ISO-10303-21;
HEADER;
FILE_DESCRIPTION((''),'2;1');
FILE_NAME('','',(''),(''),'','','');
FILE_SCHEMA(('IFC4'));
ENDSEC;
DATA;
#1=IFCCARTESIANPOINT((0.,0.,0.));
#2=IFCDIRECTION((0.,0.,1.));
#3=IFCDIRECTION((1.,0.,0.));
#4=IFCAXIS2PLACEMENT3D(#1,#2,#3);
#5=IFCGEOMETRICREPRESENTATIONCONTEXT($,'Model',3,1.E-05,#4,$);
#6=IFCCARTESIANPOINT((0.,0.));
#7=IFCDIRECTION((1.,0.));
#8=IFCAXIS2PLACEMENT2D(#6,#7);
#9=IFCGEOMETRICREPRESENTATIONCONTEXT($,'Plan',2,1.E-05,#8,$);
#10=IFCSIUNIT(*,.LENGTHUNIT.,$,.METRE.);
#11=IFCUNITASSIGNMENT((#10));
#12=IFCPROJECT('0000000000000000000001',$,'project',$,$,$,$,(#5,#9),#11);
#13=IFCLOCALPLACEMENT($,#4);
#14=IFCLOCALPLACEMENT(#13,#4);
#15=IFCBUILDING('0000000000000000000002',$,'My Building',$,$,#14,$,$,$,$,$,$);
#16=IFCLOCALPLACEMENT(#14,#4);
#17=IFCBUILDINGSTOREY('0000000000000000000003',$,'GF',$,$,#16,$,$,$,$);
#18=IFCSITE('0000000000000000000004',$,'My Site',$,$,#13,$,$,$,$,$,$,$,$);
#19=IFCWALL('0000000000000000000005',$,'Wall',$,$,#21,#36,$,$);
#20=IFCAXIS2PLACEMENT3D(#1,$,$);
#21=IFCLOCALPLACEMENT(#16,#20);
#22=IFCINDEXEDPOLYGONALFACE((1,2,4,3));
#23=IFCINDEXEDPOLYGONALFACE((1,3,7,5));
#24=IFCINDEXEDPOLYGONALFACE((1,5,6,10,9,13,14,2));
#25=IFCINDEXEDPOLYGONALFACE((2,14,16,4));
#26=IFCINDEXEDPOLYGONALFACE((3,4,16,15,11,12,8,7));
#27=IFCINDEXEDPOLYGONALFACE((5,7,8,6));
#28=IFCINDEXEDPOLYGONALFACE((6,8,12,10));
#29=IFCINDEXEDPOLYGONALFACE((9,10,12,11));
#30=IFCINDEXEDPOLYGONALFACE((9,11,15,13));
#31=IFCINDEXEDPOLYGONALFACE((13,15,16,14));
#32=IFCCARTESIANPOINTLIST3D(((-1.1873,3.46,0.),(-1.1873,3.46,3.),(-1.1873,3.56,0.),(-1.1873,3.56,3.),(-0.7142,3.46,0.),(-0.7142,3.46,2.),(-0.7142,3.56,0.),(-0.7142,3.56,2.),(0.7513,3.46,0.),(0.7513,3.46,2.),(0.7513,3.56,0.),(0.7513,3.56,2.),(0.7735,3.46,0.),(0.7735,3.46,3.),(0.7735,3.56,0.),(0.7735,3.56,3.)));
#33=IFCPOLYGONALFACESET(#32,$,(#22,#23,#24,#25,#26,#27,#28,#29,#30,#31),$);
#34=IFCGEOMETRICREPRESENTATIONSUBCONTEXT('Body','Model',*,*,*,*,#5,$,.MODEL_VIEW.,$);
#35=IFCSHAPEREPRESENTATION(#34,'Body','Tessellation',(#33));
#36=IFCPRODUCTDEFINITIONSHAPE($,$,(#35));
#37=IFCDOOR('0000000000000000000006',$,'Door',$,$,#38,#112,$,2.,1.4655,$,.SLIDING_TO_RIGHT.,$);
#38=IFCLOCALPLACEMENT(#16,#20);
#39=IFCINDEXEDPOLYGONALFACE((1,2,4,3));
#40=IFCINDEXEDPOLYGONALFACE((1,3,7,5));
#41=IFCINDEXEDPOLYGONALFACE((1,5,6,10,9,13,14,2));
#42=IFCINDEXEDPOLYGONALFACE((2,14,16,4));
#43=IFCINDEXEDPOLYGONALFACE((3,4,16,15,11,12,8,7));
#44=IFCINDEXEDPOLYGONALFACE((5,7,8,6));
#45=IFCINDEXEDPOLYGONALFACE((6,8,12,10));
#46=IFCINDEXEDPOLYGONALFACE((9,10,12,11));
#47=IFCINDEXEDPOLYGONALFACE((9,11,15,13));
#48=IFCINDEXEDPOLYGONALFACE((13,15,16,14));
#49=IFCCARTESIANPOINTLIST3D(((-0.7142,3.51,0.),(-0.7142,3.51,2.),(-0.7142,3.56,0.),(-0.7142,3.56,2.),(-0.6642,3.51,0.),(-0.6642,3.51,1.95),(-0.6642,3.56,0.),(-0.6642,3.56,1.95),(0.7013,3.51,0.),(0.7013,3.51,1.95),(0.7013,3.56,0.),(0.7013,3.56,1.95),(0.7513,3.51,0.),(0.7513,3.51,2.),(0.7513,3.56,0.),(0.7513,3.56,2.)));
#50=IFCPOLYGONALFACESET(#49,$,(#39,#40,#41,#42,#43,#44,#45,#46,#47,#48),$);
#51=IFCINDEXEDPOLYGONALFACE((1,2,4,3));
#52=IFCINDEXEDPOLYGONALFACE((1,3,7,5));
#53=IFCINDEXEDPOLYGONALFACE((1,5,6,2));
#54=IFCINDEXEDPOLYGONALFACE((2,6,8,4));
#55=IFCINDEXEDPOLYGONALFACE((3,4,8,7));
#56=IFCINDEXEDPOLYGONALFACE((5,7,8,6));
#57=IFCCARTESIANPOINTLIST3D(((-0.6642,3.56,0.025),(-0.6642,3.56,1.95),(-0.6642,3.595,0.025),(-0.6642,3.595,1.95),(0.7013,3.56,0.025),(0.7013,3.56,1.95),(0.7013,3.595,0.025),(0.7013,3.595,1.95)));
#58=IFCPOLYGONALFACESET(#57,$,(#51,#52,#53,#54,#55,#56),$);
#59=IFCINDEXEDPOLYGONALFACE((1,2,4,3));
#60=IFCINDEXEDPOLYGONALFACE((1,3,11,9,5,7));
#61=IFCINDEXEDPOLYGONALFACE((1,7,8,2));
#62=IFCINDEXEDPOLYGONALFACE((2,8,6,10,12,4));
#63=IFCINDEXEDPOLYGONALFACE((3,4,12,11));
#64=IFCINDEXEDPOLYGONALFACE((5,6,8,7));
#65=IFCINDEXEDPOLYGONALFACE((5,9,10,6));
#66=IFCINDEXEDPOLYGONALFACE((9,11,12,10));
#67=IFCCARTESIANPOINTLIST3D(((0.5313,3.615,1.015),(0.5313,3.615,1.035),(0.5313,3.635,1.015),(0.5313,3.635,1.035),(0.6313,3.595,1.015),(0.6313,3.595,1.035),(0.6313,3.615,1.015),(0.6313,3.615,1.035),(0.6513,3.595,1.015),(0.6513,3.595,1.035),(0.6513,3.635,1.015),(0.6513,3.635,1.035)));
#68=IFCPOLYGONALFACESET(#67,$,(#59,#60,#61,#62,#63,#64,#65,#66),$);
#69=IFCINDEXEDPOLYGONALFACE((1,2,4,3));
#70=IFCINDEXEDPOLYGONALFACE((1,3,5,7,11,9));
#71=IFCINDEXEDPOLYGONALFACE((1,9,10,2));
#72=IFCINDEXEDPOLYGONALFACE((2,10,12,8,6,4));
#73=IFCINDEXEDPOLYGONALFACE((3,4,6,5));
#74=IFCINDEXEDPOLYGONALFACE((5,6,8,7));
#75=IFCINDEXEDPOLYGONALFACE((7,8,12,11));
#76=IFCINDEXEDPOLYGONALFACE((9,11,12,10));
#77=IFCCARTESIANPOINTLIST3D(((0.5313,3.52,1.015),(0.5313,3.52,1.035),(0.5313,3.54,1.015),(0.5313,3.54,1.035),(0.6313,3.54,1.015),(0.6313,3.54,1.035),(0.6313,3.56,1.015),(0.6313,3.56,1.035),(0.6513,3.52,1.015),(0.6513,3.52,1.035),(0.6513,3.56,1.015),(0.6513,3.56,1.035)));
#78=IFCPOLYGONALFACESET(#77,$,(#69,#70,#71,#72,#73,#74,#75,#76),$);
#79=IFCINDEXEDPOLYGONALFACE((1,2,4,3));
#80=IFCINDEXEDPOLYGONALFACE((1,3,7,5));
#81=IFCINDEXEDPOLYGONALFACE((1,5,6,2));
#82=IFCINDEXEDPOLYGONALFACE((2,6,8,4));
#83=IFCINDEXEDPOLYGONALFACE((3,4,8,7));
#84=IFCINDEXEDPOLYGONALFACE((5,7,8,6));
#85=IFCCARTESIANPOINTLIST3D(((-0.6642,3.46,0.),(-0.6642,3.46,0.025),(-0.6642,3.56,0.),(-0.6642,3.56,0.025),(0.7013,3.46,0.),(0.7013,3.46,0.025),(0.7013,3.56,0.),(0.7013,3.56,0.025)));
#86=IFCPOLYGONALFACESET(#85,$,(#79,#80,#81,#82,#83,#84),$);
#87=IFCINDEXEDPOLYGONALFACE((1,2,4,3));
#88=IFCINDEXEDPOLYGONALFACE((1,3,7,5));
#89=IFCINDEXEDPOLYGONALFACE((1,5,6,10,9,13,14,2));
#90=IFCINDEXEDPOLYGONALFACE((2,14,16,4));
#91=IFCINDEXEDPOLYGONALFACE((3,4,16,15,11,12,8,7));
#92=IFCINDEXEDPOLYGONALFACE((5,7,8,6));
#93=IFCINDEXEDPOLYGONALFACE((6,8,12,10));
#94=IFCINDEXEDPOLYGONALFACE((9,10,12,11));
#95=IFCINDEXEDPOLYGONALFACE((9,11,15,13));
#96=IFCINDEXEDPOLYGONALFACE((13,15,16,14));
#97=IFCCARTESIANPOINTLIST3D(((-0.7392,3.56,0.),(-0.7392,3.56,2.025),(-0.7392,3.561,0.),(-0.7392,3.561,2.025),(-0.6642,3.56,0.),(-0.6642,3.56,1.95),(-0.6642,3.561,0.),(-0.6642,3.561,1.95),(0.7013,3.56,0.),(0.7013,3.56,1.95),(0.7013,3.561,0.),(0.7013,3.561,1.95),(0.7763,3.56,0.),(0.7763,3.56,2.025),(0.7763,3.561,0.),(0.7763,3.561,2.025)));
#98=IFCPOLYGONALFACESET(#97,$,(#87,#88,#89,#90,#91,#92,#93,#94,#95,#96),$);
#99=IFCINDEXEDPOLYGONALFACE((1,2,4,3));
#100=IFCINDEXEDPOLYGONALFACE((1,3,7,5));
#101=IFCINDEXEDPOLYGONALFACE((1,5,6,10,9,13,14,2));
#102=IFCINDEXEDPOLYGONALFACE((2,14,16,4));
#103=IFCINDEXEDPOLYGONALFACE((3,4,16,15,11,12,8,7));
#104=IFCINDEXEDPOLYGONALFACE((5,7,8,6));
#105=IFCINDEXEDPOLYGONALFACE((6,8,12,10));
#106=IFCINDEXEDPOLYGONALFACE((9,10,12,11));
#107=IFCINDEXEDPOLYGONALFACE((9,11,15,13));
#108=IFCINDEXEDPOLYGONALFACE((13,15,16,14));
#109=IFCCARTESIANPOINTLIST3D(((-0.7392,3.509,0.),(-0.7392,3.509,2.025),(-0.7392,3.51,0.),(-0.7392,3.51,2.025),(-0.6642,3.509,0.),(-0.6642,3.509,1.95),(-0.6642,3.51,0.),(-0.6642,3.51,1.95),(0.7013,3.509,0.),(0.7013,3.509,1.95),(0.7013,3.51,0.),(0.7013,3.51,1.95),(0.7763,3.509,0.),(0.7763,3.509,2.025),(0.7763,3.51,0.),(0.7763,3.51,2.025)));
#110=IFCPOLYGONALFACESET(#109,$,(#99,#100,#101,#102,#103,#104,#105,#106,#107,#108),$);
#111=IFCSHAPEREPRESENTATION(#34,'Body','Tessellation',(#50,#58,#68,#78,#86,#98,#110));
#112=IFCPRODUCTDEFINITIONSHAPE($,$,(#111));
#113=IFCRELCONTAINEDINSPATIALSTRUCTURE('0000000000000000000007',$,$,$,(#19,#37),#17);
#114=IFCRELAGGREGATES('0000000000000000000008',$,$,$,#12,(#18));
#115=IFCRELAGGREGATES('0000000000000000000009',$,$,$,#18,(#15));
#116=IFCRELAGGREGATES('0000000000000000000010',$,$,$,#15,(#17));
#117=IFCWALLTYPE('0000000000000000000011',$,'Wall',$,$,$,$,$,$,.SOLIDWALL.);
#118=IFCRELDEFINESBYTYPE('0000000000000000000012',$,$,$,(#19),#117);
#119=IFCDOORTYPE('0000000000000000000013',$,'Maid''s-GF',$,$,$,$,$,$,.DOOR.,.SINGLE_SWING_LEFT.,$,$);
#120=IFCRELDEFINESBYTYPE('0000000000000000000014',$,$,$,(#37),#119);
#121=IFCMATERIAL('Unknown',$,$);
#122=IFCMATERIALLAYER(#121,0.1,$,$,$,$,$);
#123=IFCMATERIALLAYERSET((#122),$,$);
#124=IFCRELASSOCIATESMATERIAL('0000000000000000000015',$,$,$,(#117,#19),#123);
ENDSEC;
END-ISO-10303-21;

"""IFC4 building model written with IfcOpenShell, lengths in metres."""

from ifc_helpers import new_model, entity, si_unit, frame, origin_with_axes, origin_2d_with_axis, place, context, subcontext, project, spatial, line, indexed_curve, outline, extrude, shape, source, transform, mapped, material, layer, layer_set, layer_usage, type_object, type_shapes, element, fill, save


model = new_model("IFC4")

# Units and contexts
model_context = context("Model", 3, precision=1e-05, world=origin_with_axes())
plan_context = context("Plan", 2, precision=1e-05, world=origin_2d_with_axis())
body_context_1 = subcontext(model_context, "Body", "Model", "MODEL_VIEW")
body_context_2 = subcontext(plan_context, "Body", "Plan", "PLAN_VIEW")
ifc_project = project(units=[si_unit("LENGTHUNIT", "METRE")], contexts=[model_context, plan_context])

# Site, building, storey
site_placement = place(None, origin_with_axes())
site = spatial("IfcSite", under=ifc_project, at=site_placement, Name="My Site")
building_placement = place(site_placement, origin_with_axes())
building = spatial("IfcBuilding", under=site, at=building_placement, Name="My Building")
storey_placement = place(building_placement, origin_with_axes())
storey = spatial("IfcBuildingStorey", under=building, at=storey_placement, Name="GF")

# Shared definitions
ifc_material = material(Name="Unknown")

# Shared definitions
ifc_layer_1 = layer(ifc_material, 0.1)
ifc_layer_set_1 = layer_set([ifc_layer_1])
wall_type = type_object("IfcWallType", Name="Wall", PredefinedType="SOLIDWALL", material=ifc_layer_set_1)

# Wall, opening, door
ifc_layer_usage_1 = layer_usage(ifc_layer_set_1, "AXIS2", "POSITIVE", 0.0)
wall_1_placement = place(storey_placement, frame((0.7735, 3.56, 0.0), z_axis=(0.0, 0.0, 1.0), x_axis=(-1.0, 0.0, 0.0)))
wall_1 = element("IfcWall", 1, at=wall_1_placement, inside=storey, type_object=wall_type, material=ifc_layer_usage_1, Name="Wall", context=body_context_1, shape_type="SweptSolid", body=[
    extrude(outline(indexed_curve([(0.0, 0.0), (0.0, 0.1), (1.9608, 0.1), (1.9608, 0.0)], segments=[line(1, 2, 3, 4, 1)])), origin_with_axes(), (0.0, 0.0, 1.0), 3.0),
])
shared_shape_1 = source(origin_with_axes(), body_context_1, "Body", "SweptSolid", [
    extrude(outline(indexed_curve([(0.0, 0.0), (1.4655, 0.0), (1.4655, 2.0), (0.0, 2.0)], segments=[line(1, 2, 3, 4, 1)])), frame((0.0, -0.6, 0.0), z_axis=(0.0, -1.0, 0.0), x_axis=(1.0, 0.0, 0.0)), (0.0, 0.0, -1.0), 1.2),
])
opening_1_placement = place(wall_1_placement, frame((0.0222, 0.0, 0.0), z_axis=(0.0, 0.0, 1.0), x_axis=(1.0, 0.0, 0.0)))
opening_1 = element("IfcOpeningElement", 2, at=opening_1_placement, cuts=wall_1, PredefinedType="OPENING", context=body_context_1, shape_type="MappedRepresentation", body=[
    mapped(shared_shape_1, transform((0.0, 0.0, 0.0), x_axis=(1.0, 0.0, 0.0), y_axis=(0.0, 1.0, 0.0), z_axis=(0.0, 0.0, 1.0), scale=1.0)),
])
door_type_1 = type_object("IfcDoorType", Name="Maid's-GF", OperationType="SINGLE_SWING_LEFT", PredefinedType="DOOR")
shared_shape_2 = source(origin_with_axes(), body_context_1, "Body", "SweptSolid", [
    extrude(outline(indexed_curve([(0.0, 0.0), (0.0, 2.0), (1.4655, 2.0), (1.4655, 0.0), (1.4155, 0.0), (1.4155, 1.95), (0.05, 1.95), (0.05, 0.0)], segments=[line(1, 2, 3, 4, 5, 6, 7, 8, 1)])), frame((0.0, 0.0, 0.0), z_axis=(0.0, -1.0, 0.0), x_axis=(1.0, 0.0, 0.0)), (0.0, 0.0, -1.0), 0.05),
    extrude(outline(indexed_curve([(0.0, 0.0), (1.3655, 0.0), (1.3655, 0.035), (0.0, 0.035)], segments=[line(1, 2, 3, 4, 1)])), frame((0.05, -0.035, 0.025), z_axis=(0.0, 0.0, 1.0), x_axis=(1.0, 0.0, 0.0)), (0.0, 0.0, 1.0), 1.925),
    extrude(outline(indexed_curve([(0.0, 0.0), (0.0, -0.04), (0.12, -0.04), (0.12, -0.02), (0.02, -0.02), (0.02, 0.0)], segments=[line(1, 2, 3, 4, 5, 6, 1)])), frame((0.1, -0.035, 1.015), z_axis=(0.0, 0.0, 1.0), x_axis=(1.0, 0.0, 0.0)), (0.0, 0.0, 1.0), 0.02),
    extrude(outline(indexed_curve([(0.0, 0.0), (0.0, 0.04), (0.12, 0.04), (0.12, 0.02), (0.02, 0.02), (0.02, 0.0)], segments=[line(1, 2, 3, 4, 5, 6, 1)])), frame((0.1, 0.0, 1.015), z_axis=(0.0, 0.0, 1.0), x_axis=(1.0, 0.0, 0.0)), (0.0, 0.0, 1.0), 0.02),
    extrude(outline(indexed_curve([(0.0, 0.0), (1.3655, 0.0), (1.3655, 0.1), (0.0, 0.1)], segments=[line(1, 2, 3, 4, 1)])), frame((0.05, 0.0, 0.0), z_axis=(0.0, 0.0, 1.0), x_axis=(1.0, 0.0, 0.0)), (0.0, 0.0, 1.0), 0.025),
    extrude(outline(indexed_curve([(0.0, 0.0), (0.0, 2.025), (1.5155, 2.025), (1.5155, 0.0), (1.4405, 0.0), (1.4405, 1.95), (0.075, 1.95), (0.075, 0.0)], segments=[line(1, 2, 3, 4, 5, 6, 7, 8, 1)])), frame((-0.025, -0.001, 0.0), z_axis=(0.0, -1.0, 0.0), x_axis=(1.0, 0.0, 0.0)), (0.0, 0.0, -1.0), 0.001),
    extrude(outline(indexed_curve([(0.0, 0.0), (0.0, 2.025), (1.5155, 2.025), (1.5155, 0.0), (1.4405, 0.0), (1.4405, 1.95), (0.075, 1.95), (0.075, 0.0)], segments=[line(1, 2, 3, 4, 5, 6, 7, 8, 1)])), frame((-0.025, 0.05, 0.0), z_axis=(0.0, -1.0, 0.0), x_axis=(1.0, 0.0, 0.0)), (0.0, 0.0, -1.0), 0.001),
])
shared_shape_3 = source(origin_with_axes(), body_context_2, "Body", "Curve2D", [
    entity("IfcIndexedPolyCurve", entity("IfcCartesianPointList2D", [[0.0, 0.0], [0.05, 0.0], [0.05, 0.05], [0.0, 0.05]]), [entity("IfcLineIndex", [1, 2, 3, 4, 1])]),
    entity("IfcIndexedPolyCurve", entity("IfcCartesianPointList2D", [[1.4655, 0.0], [1.4155, 0.0], [1.4155, 0.05], [1.4655, 0.05]]), [entity("IfcLineIndex", [1, 2, 3, 4, 1])]),
    entity("IfcIndexedPolyCurve", entity("IfcCartesianPointList2D", [[2.0983, -0.035], [0.7328, -0.035], [0.7328, 0.0], [2.0983, 0.0]]), [entity("IfcLineIndex", [1, 2, 3, 4, 1])]),
])
type_shapes(door_type_1, [shared_shape_2, shared_shape_3])
door_1_placement = place(opening_1_placement, frame((0.0, 0.0, 0.0), z_axis=(0.0, 0.0, 1.0), x_axis=(1.0, 0.0, 0.0)))
door_1 = element("IfcDoor", 3, at=door_1_placement, inside=storey, type_object=door_type_1, Name="Door", OperationType="SLIDING_TO_RIGHT", OverallHeight=2.0, OverallWidth=1.4655, shapes=[
    shape(body_context_1, "Body", "MappedRepresentation", [mapped(shared_shape_2, transform((0.0, 0.0, 0.0), x_axis=(1.0, 0.0, 0.0), y_axis=(0.0, 1.0, 0.0), z_axis=(0.0, 0.0, 1.0), scale=1.0))]),
    shape(body_context_2, "Body", "MappedRepresentation", [mapped(shared_shape_3, transform((0.0, 0.0, 0.0), x_axis=(1.0, 0.0, 0.0), y_axis=(0.0, 1.0, 0.0), z_axis=(0.0, 0.0, 1.0), scale=1.0))]),
])
fill(opening_1, door_1)

save(model, "model.ifc")
